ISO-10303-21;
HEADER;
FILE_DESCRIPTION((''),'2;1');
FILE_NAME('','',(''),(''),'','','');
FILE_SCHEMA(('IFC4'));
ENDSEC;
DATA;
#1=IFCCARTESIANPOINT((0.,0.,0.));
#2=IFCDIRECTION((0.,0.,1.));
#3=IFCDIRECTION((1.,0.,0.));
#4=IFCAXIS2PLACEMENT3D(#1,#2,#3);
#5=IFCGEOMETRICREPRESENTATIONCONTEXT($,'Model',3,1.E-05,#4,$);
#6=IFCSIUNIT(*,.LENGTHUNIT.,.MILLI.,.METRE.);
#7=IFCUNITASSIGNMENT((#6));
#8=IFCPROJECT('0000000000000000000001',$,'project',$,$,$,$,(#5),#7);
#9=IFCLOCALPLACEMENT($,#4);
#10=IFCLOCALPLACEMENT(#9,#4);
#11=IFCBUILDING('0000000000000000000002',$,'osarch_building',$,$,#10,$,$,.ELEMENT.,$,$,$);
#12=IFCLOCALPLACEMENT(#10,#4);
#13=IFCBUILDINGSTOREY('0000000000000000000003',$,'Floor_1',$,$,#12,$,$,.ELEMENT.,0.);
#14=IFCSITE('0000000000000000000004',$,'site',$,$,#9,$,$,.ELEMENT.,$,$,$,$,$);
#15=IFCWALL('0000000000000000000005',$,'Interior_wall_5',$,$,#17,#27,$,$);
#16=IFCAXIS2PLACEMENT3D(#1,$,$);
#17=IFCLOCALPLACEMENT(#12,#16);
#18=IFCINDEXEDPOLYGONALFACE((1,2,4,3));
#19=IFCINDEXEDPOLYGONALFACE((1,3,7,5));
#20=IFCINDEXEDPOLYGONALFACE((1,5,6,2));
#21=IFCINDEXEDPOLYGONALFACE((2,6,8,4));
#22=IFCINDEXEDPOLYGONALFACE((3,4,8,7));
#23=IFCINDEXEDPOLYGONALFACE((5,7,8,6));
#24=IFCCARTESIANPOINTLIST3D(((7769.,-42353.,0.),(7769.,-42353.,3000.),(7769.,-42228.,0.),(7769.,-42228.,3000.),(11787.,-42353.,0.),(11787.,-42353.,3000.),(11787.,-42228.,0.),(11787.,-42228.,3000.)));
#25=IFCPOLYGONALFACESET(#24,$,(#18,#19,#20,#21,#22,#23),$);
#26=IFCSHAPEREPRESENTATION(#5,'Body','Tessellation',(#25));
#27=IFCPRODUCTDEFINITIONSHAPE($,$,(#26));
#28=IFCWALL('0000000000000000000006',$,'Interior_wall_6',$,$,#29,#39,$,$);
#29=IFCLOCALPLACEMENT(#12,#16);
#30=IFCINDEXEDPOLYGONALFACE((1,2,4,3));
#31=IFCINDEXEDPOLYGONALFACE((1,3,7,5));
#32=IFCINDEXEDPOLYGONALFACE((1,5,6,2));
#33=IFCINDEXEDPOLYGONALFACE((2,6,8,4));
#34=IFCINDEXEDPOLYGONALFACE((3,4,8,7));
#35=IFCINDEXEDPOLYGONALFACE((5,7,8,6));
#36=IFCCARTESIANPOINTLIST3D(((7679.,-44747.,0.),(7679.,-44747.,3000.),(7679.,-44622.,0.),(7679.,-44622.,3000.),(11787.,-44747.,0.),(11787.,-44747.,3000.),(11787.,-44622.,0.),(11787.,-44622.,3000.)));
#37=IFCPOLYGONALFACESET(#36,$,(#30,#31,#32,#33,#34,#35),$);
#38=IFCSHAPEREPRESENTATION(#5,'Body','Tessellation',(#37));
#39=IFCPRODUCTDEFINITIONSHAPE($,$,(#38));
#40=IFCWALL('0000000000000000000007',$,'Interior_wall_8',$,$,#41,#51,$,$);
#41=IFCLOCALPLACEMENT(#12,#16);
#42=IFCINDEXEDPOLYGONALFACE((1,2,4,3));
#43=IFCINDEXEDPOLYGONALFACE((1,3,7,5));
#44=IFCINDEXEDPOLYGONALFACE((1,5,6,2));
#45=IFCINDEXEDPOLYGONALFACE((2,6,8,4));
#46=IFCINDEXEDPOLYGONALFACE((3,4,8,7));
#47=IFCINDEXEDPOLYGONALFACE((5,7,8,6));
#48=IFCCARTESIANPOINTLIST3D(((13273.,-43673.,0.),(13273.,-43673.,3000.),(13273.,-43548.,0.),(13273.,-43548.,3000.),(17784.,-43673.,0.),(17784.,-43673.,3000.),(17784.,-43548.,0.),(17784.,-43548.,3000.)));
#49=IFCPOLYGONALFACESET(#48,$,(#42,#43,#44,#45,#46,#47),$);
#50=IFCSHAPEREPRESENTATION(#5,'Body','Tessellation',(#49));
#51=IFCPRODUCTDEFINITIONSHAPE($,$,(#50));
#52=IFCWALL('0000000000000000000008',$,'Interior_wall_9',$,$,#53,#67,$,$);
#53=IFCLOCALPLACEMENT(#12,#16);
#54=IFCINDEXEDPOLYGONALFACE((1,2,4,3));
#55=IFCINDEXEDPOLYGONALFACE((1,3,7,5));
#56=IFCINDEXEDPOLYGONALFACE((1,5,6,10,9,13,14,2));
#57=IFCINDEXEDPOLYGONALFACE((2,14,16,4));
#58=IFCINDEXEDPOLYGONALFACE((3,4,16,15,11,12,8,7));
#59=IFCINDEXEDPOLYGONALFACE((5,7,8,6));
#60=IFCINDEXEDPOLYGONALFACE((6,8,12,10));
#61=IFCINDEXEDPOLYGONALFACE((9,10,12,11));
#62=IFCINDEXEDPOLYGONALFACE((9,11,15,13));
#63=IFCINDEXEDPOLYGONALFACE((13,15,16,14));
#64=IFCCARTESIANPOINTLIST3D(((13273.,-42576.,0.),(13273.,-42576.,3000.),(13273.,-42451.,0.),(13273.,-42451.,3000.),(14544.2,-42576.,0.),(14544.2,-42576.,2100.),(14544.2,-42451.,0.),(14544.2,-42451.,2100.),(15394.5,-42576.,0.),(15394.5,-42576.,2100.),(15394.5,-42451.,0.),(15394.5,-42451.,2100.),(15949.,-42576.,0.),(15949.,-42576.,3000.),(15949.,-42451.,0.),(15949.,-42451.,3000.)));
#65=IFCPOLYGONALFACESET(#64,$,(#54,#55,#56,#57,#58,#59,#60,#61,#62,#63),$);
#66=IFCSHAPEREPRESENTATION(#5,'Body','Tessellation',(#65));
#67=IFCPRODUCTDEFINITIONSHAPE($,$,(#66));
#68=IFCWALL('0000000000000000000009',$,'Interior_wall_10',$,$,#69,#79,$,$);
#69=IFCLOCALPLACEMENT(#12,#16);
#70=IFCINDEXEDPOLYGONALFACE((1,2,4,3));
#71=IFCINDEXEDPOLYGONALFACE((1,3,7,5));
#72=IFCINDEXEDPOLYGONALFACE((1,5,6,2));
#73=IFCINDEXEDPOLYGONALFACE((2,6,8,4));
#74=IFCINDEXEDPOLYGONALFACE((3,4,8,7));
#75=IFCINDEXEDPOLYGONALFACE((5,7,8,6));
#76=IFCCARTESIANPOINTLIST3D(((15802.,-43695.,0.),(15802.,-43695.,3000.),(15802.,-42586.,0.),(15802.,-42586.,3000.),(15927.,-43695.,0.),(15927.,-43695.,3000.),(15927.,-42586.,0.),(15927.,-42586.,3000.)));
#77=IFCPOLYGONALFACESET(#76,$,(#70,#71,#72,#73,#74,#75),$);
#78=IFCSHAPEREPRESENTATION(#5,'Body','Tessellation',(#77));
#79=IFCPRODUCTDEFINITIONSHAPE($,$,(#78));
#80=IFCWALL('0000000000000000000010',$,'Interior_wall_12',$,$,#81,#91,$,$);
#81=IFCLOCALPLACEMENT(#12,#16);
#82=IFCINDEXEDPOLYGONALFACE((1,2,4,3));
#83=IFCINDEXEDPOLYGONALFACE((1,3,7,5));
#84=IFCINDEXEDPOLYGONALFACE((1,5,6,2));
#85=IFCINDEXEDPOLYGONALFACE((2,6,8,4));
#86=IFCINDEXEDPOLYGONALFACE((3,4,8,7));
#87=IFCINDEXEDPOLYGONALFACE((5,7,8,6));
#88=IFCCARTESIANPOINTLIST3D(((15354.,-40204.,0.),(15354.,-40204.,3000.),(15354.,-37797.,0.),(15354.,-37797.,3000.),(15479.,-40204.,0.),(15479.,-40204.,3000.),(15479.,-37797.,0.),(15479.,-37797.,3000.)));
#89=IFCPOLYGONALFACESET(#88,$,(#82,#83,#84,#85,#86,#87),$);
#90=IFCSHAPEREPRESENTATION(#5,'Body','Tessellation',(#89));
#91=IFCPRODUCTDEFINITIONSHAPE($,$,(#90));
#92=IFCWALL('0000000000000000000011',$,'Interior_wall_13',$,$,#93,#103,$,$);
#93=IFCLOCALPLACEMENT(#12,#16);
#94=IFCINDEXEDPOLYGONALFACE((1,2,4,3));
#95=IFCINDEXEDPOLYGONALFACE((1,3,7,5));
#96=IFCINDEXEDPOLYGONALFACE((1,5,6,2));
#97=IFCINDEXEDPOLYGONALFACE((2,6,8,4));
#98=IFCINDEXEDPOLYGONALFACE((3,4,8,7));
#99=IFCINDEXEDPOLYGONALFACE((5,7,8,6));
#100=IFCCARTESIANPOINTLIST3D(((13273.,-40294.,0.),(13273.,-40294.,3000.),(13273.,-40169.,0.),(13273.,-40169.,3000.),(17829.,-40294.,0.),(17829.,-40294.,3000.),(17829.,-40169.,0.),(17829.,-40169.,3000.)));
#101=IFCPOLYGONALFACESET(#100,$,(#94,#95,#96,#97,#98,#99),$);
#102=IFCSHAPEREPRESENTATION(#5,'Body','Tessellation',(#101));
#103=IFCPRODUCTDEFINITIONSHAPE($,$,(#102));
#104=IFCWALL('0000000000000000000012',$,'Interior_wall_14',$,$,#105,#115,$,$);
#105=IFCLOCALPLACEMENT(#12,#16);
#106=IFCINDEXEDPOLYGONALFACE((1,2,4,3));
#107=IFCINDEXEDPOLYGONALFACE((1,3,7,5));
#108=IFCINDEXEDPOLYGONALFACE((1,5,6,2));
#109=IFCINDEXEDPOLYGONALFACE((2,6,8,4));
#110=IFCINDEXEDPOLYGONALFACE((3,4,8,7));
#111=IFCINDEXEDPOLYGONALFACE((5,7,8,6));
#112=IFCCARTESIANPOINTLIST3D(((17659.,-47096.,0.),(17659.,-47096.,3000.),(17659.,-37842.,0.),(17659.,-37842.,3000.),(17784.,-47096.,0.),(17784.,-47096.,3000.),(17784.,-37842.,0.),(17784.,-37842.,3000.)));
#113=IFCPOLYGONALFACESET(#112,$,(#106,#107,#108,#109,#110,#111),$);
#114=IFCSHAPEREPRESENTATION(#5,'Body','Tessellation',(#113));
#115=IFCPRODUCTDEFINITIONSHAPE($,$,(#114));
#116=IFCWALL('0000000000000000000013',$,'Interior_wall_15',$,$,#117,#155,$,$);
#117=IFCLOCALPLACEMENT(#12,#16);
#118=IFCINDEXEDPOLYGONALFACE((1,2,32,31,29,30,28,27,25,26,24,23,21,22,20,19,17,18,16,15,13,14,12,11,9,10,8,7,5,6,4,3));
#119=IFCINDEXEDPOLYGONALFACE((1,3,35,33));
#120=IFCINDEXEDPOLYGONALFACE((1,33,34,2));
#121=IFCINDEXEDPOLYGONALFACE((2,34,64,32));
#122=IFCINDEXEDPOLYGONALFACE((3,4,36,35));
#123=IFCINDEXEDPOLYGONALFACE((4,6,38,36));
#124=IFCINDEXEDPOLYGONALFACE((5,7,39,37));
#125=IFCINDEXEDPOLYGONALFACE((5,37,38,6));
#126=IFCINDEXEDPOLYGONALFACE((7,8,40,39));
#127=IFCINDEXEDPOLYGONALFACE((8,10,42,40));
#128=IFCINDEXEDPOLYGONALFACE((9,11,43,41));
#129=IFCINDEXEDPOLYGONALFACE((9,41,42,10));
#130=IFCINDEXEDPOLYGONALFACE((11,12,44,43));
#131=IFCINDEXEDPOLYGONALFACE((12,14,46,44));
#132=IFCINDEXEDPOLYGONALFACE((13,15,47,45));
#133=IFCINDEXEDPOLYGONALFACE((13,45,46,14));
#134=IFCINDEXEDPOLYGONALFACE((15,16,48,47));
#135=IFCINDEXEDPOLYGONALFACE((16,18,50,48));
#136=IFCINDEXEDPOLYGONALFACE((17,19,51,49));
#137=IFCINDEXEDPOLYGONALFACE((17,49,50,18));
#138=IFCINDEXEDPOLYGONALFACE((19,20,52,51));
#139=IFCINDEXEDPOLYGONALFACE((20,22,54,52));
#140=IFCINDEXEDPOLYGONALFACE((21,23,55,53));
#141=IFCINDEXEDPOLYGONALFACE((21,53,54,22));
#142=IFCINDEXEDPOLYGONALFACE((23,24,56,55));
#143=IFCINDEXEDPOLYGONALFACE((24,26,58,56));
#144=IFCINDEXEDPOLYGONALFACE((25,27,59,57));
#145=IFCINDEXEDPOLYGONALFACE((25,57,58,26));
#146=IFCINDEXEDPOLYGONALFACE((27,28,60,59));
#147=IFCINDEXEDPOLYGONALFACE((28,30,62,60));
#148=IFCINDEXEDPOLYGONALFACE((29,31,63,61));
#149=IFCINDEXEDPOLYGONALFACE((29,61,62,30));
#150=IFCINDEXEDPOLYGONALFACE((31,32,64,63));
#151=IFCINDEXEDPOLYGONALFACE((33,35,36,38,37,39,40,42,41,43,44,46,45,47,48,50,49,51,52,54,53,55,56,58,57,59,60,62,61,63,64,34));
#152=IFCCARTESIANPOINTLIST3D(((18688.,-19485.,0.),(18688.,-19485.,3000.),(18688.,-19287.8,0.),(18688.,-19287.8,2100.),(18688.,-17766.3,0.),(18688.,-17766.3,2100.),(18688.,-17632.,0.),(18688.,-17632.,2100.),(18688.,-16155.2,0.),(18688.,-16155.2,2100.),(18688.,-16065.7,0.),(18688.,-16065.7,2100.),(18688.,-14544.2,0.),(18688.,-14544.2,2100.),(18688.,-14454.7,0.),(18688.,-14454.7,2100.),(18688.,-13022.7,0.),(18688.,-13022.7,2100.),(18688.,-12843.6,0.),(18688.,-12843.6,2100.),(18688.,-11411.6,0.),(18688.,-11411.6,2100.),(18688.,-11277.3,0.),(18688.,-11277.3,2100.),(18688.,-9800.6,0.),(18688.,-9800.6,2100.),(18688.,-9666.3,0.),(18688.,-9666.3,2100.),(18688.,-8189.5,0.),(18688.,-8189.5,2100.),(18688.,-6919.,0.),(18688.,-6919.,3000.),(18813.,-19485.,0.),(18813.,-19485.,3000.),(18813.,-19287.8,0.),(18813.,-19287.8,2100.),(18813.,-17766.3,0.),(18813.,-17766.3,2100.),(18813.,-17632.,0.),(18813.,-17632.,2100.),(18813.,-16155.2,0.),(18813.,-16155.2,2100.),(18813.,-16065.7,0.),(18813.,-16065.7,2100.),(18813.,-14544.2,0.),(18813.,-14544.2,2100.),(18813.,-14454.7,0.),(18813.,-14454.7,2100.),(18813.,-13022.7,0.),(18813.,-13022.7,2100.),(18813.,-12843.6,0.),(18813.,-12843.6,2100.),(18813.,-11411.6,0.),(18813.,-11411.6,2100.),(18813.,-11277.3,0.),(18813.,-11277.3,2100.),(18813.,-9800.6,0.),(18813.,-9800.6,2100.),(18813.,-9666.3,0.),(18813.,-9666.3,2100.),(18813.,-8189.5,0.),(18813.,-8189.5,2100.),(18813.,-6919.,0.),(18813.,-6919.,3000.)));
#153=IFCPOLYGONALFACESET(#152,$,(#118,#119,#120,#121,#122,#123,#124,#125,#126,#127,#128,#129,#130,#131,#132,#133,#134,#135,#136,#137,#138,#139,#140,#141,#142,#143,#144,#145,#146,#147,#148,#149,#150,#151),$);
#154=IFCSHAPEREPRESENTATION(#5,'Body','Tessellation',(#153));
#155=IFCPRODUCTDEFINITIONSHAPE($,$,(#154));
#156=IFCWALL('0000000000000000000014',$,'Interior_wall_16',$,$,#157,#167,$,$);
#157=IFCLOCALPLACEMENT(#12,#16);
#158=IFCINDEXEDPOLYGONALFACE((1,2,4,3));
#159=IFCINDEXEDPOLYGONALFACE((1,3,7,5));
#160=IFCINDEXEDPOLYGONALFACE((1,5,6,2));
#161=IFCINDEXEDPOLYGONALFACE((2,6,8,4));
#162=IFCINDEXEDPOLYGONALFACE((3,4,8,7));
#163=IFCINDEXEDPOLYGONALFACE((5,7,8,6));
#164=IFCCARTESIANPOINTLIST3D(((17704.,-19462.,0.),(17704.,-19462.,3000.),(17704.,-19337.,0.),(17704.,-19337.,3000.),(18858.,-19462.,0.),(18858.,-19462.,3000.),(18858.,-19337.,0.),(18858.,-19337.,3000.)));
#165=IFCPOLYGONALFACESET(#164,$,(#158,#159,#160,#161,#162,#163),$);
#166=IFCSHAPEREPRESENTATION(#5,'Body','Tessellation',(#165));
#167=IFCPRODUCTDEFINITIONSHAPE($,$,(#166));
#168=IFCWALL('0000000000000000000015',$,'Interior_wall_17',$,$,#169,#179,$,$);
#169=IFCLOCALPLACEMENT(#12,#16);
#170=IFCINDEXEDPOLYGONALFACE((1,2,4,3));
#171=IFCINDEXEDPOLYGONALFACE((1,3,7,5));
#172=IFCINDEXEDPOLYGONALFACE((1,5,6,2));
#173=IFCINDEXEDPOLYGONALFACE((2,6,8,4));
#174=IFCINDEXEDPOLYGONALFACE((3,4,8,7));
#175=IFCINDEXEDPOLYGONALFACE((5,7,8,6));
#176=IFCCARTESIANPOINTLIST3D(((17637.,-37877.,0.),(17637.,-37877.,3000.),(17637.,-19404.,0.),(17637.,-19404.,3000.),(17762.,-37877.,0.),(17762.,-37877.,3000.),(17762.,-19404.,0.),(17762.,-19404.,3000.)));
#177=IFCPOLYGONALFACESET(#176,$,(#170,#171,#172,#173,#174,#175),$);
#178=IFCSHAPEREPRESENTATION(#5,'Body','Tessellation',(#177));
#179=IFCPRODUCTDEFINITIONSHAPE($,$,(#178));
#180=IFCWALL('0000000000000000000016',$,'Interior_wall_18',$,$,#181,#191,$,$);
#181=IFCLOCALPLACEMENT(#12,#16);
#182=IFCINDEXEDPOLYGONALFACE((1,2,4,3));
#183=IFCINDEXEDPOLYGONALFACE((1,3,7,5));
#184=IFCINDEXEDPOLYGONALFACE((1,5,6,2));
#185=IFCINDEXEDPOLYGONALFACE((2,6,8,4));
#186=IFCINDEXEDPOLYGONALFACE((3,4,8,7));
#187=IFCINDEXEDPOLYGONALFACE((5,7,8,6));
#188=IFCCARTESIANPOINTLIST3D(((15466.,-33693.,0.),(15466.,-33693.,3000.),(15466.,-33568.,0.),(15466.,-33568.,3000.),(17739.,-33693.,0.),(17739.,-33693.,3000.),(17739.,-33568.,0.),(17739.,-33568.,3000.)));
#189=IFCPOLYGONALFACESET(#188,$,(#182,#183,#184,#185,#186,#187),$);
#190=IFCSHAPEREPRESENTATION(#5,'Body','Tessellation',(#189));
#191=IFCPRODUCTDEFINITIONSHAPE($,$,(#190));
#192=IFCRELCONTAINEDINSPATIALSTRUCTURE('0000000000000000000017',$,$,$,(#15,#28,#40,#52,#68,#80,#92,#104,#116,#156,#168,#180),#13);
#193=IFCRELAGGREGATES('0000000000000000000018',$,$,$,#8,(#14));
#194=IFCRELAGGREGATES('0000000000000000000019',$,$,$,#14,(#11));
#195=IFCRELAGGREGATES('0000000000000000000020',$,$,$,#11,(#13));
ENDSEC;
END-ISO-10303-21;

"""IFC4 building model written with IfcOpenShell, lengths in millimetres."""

from ifc_helpers import new_model, si_unit, origin_with_axes, place, context, project, spatial, polyline, outline, extrude, element, save


model = new_model("IFC4")

# Units and contexts
model_context = context("Model", 3, precision=1e-05, world=origin_with_axes())
ifc_project = project(units=[si_unit("LENGTHUNIT", "METRE", prefix="MILLI")], contexts=[model_context])

# Site, building, storey
site_placement = place(None, origin_with_axes())
site = spatial("IfcSite", under=ifc_project, at=site_placement, Name="site", CompositionType="ELEMENT")
building_placement = place(site_placement, origin_with_axes())
building = spatial("IfcBuilding", under=site, at=building_placement, Name="osarch_building", CompositionType="ELEMENT")
storey_placement = place(building_placement, origin_with_axes())
storey = spatial("IfcBuildingStorey", under=building, at=storey_placement, Name="Floor_1", CompositionType="ELEMENT", Elevation=0.0)

# Walls
element("IfcWall", 1, inside=storey, Name="Interior_wall_5", context=model_context, shape_type="SweptSolid", body=[
    extrude(outline(polyline([(11787.0, -42228.0, 0.0), (11787.0, -42353.0, 0.0), (7769.0, -42353.0, 0.0), (7769.0, -42228.0, 0.0), (11787.0, -42228.0, 0.0)])), origin_with_axes(), (0.0, 0.0, 1.0), 3000.0),
])
element("IfcWall", 2, inside=storey, Name="Interior_wall_6", context=model_context, shape_type="SweptSolid", body=[
    extrude(outline(polyline([(11787.0, -44622.0, 0.0), (11787.0, -44747.0, 0.0), (7679.0, -44747.0, 0.0), (7679.0, -44622.0, 0.0), (11787.0, -44622.0, 0.0)])), origin_with_axes(), (0.0, 0.0, 1.0), 3000.0),
])

# Wall
element("IfcWall", 3, inside=storey, Name="Interior_wall_8", context=model_context, shape_type="SweptSolid", body=[
    extrude(outline(polyline([(17784.0, -43548.0, 0.0), (17784.0, -43673.0, 0.0), (13273.0, -43673.0, 0.0), (13273.0, -43548.0, 0.0), (17784.0, -43548.0, 0.0)])), origin_with_axes(), (0.0, 0.0, 1.0), 3000.0),
])

# Wall, opening
wall_1 = element("IfcWall", 4, inside=storey, Name="Interior_wall_9", context=model_context, shape_type="SweptSolid", body=[
    extrude(outline(polyline([(15949.0, -42451.0, 0.0), (15949.0, -42576.0, 0.0), (13273.0, -42576.0, 0.0), (13273.0, -42451.0, 0.0), (15949.0, -42451.0, 0.0)])), origin_with_axes(), (0.0, 0.0, 1.0), 3000.0),
])
element("IfcOpeningElement", 5, inside=storey, cuts=wall_1, context=model_context, shape_type="SweptSolid", body=[
    extrude(outline(polyline([(14544.2, -41618.8, 0.0), (14544.2, -42737.6, 0.0), (15394.5, -42737.6, 0.0), (15394.5, -41618.8, 0.0), (14544.2, -41618.8, 0.0)])), origin_with_axes(), (0.0, 0.0, 1.0), 2100.0),
])

# Wall
element("IfcWall", 6, inside=storey, Name="Interior_wall_10", context=model_context, shape_type="SweptSolid", body=[
    extrude(outline(polyline([(15802.0, -42586.0, 0.0), (15927.0, -42586.0, 0.0), (15927.0, -43695.0, 0.0), (15802.0, -43695.0, 0.0), (15802.0, -42586.0, 0.0)])), origin_with_axes(), (0.0, 0.0, 1.0), 3000.0),
])

# Walls
element("IfcWall", 7, inside=storey, Name="Interior_wall_12", context=model_context, shape_type="SweptSolid", body=[
    extrude(outline(polyline([(15354.0, -37797.0, 0.0), (15479.0, -37797.0, 0.0), (15479.0, -40204.0, 0.0), (15354.0, -40204.0, 0.0), (15354.0, -37797.0, 0.0)])), origin_with_axes(), (0.0, 0.0, 1.0), 3000.0),
])
element("IfcWall", 8, inside=storey, Name="Interior_wall_13", context=model_context, shape_type="SweptSolid", body=[
    extrude(outline(polyline([(17829.0, -40169.0, 0.0), (17829.0, -40294.0, 0.0), (13273.0, -40294.0, 0.0), (13273.0, -40169.0, 0.0), (17829.0, -40169.0, 0.0)])), origin_with_axes(), (0.0, 0.0, 1.0), 3000.0),
])
element("IfcWall", 9, inside=storey, Name="Interior_wall_14", context=model_context, shape_type="SweptSolid", body=[
    extrude(outline(polyline([(17659.0, -37842.0, 0.0), (17784.0, -37842.0, 0.0), (17784.0, -47096.0, 0.0), (17659.0, -47096.0, 0.0), (17659.0, -37842.0, 0.0)])), origin_with_axes(), (0.0, 0.0, 1.0), 3000.0),
])

# Wall, openings
wall_2 = element("IfcWall", 10, inside=storey, Name="Interior_wall_15", context=model_context, shape_type="SweptSolid", body=[
    extrude(outline(polyline([(18688.0, -6919.0, 0.0), (18813.0, -6919.0, 0.0), (18813.0, -19485.0, 0.0), (18688.0, -19485.0, 0.0), (18688.0, -6919.0, 0.0)])), origin_with_axes(), (0.0, 0.0, 1.0), 3000.0),
])
element("IfcOpeningElement", 11, inside=storey, cuts=wall_2, context=model_context, shape_type="SweptSolid", body=[
    extrude(outline(polyline([(17766.3, -17766.3, 0.0), (17766.3, -19287.8, 0.0), (19780.1, -19287.8, 0.0), (19780.1, -17766.3, 0.0), (17766.3, -17766.3, 0.0)])), origin_with_axes(), (0.0, 0.0, 1.0), 2100.0),
])
element("IfcOpeningElement", 12, inside=storey, cuts=wall_2, context=model_context, shape_type="SweptSolid", body=[
    extrude(outline(polyline([(17766.3, -16155.2, 0.0), (17766.3, -17632.0, 0.0), (19690.6, -17632.0, 0.0), (19690.6, -16155.2, 0.0), (17766.3, -16155.2, 0.0)])), origin_with_axes(), (0.0, 0.0, 1.0), 2100.0),
])
element("IfcOpeningElement", 13, inside=storey, cuts=wall_2, context=model_context, shape_type="SweptSolid", body=[
    extrude(outline(polyline([(17766.3, -14544.2, 0.0), (17766.3, -16065.7, 0.0), (19735.4, -16065.7, 0.0), (19735.4, -14544.2, 0.0), (17766.3, -14544.2, 0.0)])), origin_with_axes(), (0.0, 0.0, 1.0), 2100.0),
])
element("IfcOpeningElement", 14, inside=storey, cuts=wall_2, context=model_context, shape_type="SweptSolid", body=[
    extrude(outline(polyline([(17766.3, -13022.7, 0.0), (17766.3, -14454.7, 0.0), (19735.4, -14454.7, 0.0), (19735.4, -13022.7, 0.0), (17766.3, -13022.7, 0.0)])), origin_with_axes(), (0.0, 0.0, 1.0), 2100.0),
])
element("IfcOpeningElement", 15, inside=storey, cuts=wall_2, context=model_context, shape_type="SweptSolid", body=[
    extrude(outline(polyline([(17766.3, -11411.6, 0.0), (17766.3, -12843.6, 0.0), (19735.4, -12843.6, 0.0), (19735.4, -11411.6, 0.0), (17766.3, -11411.6, 0.0)])), origin_with_axes(), (0.0, 0.0, 1.0), 2100.0),
])
element("IfcOpeningElement", 16, inside=storey, cuts=wall_2, context=model_context, shape_type="SweptSolid", body=[
    extrude(outline(polyline([(17855.8, -9800.6, 0.0), (17855.8, -11277.3, 0.0), (19780.1, -11277.3, 0.0), (19780.1, -9800.6, 0.0), (17855.8, -9800.6, 0.0)])), origin_with_axes(), (0.0, 0.0, 1.0), 2100.0),
])
element("IfcOpeningElement", 17, inside=storey, cuts=wall_2, context=model_context, shape_type="SweptSolid", body=[
    extrude(outline(polyline([(17945.3, -8189.5, 0.0), (17945.3, -9666.3, 0.0), (19690.6, -9666.3, 0.0), (19690.6, -8189.5, 0.0), (17945.3, -8189.5, 0.0)])), origin_with_axes(), (0.0, 0.0, 1.0), 2100.0),
])

# Walls
element("IfcWall", 18, inside=storey, Name="Interior_wall_16", context=model_context, shape_type="SweptSolid", body=[
    extrude(outline(polyline([(18858.0, -19337.0, 0.0), (18858.0, -19462.0, 0.0), (17704.0, -19462.0, 0.0), (17704.0, -19337.0, 0.0), (18858.0, -19337.0, 0.0)])), origin_with_axes(), (0.0, 0.0, 1.0), 3000.0),
])
element("IfcWall", 19, inside=storey, Name="Interior_wall_17", context=model_context, shape_type="SweptSolid", body=[
    extrude(outline(polyline([(17637.0, -19404.0, 0.0), (17762.0, -19404.0, 0.0), (17762.0, -37877.0, 0.0), (17637.0, -37877.0, 0.0), (17637.0, -19404.0, 0.0)])), origin_with_axes(), (0.0, 0.0, 1.0), 3000.0),
])
element("IfcWall", 20, inside=storey, Name="Interior_wall_18", context=model_context, shape_type="SweptSolid", body=[
    extrude(outline(polyline([(17739.0, -33568.0, 0.0), (17739.0, -33693.0, 0.0), (15466.0, -33693.0, 0.0), (15466.0, -33568.0, 0.0), (17739.0, -33568.0, 0.0)])), origin_with_axes(), (0.0, 0.0, 1.0), 3000.0),
])

save(model, "model.ifc")
